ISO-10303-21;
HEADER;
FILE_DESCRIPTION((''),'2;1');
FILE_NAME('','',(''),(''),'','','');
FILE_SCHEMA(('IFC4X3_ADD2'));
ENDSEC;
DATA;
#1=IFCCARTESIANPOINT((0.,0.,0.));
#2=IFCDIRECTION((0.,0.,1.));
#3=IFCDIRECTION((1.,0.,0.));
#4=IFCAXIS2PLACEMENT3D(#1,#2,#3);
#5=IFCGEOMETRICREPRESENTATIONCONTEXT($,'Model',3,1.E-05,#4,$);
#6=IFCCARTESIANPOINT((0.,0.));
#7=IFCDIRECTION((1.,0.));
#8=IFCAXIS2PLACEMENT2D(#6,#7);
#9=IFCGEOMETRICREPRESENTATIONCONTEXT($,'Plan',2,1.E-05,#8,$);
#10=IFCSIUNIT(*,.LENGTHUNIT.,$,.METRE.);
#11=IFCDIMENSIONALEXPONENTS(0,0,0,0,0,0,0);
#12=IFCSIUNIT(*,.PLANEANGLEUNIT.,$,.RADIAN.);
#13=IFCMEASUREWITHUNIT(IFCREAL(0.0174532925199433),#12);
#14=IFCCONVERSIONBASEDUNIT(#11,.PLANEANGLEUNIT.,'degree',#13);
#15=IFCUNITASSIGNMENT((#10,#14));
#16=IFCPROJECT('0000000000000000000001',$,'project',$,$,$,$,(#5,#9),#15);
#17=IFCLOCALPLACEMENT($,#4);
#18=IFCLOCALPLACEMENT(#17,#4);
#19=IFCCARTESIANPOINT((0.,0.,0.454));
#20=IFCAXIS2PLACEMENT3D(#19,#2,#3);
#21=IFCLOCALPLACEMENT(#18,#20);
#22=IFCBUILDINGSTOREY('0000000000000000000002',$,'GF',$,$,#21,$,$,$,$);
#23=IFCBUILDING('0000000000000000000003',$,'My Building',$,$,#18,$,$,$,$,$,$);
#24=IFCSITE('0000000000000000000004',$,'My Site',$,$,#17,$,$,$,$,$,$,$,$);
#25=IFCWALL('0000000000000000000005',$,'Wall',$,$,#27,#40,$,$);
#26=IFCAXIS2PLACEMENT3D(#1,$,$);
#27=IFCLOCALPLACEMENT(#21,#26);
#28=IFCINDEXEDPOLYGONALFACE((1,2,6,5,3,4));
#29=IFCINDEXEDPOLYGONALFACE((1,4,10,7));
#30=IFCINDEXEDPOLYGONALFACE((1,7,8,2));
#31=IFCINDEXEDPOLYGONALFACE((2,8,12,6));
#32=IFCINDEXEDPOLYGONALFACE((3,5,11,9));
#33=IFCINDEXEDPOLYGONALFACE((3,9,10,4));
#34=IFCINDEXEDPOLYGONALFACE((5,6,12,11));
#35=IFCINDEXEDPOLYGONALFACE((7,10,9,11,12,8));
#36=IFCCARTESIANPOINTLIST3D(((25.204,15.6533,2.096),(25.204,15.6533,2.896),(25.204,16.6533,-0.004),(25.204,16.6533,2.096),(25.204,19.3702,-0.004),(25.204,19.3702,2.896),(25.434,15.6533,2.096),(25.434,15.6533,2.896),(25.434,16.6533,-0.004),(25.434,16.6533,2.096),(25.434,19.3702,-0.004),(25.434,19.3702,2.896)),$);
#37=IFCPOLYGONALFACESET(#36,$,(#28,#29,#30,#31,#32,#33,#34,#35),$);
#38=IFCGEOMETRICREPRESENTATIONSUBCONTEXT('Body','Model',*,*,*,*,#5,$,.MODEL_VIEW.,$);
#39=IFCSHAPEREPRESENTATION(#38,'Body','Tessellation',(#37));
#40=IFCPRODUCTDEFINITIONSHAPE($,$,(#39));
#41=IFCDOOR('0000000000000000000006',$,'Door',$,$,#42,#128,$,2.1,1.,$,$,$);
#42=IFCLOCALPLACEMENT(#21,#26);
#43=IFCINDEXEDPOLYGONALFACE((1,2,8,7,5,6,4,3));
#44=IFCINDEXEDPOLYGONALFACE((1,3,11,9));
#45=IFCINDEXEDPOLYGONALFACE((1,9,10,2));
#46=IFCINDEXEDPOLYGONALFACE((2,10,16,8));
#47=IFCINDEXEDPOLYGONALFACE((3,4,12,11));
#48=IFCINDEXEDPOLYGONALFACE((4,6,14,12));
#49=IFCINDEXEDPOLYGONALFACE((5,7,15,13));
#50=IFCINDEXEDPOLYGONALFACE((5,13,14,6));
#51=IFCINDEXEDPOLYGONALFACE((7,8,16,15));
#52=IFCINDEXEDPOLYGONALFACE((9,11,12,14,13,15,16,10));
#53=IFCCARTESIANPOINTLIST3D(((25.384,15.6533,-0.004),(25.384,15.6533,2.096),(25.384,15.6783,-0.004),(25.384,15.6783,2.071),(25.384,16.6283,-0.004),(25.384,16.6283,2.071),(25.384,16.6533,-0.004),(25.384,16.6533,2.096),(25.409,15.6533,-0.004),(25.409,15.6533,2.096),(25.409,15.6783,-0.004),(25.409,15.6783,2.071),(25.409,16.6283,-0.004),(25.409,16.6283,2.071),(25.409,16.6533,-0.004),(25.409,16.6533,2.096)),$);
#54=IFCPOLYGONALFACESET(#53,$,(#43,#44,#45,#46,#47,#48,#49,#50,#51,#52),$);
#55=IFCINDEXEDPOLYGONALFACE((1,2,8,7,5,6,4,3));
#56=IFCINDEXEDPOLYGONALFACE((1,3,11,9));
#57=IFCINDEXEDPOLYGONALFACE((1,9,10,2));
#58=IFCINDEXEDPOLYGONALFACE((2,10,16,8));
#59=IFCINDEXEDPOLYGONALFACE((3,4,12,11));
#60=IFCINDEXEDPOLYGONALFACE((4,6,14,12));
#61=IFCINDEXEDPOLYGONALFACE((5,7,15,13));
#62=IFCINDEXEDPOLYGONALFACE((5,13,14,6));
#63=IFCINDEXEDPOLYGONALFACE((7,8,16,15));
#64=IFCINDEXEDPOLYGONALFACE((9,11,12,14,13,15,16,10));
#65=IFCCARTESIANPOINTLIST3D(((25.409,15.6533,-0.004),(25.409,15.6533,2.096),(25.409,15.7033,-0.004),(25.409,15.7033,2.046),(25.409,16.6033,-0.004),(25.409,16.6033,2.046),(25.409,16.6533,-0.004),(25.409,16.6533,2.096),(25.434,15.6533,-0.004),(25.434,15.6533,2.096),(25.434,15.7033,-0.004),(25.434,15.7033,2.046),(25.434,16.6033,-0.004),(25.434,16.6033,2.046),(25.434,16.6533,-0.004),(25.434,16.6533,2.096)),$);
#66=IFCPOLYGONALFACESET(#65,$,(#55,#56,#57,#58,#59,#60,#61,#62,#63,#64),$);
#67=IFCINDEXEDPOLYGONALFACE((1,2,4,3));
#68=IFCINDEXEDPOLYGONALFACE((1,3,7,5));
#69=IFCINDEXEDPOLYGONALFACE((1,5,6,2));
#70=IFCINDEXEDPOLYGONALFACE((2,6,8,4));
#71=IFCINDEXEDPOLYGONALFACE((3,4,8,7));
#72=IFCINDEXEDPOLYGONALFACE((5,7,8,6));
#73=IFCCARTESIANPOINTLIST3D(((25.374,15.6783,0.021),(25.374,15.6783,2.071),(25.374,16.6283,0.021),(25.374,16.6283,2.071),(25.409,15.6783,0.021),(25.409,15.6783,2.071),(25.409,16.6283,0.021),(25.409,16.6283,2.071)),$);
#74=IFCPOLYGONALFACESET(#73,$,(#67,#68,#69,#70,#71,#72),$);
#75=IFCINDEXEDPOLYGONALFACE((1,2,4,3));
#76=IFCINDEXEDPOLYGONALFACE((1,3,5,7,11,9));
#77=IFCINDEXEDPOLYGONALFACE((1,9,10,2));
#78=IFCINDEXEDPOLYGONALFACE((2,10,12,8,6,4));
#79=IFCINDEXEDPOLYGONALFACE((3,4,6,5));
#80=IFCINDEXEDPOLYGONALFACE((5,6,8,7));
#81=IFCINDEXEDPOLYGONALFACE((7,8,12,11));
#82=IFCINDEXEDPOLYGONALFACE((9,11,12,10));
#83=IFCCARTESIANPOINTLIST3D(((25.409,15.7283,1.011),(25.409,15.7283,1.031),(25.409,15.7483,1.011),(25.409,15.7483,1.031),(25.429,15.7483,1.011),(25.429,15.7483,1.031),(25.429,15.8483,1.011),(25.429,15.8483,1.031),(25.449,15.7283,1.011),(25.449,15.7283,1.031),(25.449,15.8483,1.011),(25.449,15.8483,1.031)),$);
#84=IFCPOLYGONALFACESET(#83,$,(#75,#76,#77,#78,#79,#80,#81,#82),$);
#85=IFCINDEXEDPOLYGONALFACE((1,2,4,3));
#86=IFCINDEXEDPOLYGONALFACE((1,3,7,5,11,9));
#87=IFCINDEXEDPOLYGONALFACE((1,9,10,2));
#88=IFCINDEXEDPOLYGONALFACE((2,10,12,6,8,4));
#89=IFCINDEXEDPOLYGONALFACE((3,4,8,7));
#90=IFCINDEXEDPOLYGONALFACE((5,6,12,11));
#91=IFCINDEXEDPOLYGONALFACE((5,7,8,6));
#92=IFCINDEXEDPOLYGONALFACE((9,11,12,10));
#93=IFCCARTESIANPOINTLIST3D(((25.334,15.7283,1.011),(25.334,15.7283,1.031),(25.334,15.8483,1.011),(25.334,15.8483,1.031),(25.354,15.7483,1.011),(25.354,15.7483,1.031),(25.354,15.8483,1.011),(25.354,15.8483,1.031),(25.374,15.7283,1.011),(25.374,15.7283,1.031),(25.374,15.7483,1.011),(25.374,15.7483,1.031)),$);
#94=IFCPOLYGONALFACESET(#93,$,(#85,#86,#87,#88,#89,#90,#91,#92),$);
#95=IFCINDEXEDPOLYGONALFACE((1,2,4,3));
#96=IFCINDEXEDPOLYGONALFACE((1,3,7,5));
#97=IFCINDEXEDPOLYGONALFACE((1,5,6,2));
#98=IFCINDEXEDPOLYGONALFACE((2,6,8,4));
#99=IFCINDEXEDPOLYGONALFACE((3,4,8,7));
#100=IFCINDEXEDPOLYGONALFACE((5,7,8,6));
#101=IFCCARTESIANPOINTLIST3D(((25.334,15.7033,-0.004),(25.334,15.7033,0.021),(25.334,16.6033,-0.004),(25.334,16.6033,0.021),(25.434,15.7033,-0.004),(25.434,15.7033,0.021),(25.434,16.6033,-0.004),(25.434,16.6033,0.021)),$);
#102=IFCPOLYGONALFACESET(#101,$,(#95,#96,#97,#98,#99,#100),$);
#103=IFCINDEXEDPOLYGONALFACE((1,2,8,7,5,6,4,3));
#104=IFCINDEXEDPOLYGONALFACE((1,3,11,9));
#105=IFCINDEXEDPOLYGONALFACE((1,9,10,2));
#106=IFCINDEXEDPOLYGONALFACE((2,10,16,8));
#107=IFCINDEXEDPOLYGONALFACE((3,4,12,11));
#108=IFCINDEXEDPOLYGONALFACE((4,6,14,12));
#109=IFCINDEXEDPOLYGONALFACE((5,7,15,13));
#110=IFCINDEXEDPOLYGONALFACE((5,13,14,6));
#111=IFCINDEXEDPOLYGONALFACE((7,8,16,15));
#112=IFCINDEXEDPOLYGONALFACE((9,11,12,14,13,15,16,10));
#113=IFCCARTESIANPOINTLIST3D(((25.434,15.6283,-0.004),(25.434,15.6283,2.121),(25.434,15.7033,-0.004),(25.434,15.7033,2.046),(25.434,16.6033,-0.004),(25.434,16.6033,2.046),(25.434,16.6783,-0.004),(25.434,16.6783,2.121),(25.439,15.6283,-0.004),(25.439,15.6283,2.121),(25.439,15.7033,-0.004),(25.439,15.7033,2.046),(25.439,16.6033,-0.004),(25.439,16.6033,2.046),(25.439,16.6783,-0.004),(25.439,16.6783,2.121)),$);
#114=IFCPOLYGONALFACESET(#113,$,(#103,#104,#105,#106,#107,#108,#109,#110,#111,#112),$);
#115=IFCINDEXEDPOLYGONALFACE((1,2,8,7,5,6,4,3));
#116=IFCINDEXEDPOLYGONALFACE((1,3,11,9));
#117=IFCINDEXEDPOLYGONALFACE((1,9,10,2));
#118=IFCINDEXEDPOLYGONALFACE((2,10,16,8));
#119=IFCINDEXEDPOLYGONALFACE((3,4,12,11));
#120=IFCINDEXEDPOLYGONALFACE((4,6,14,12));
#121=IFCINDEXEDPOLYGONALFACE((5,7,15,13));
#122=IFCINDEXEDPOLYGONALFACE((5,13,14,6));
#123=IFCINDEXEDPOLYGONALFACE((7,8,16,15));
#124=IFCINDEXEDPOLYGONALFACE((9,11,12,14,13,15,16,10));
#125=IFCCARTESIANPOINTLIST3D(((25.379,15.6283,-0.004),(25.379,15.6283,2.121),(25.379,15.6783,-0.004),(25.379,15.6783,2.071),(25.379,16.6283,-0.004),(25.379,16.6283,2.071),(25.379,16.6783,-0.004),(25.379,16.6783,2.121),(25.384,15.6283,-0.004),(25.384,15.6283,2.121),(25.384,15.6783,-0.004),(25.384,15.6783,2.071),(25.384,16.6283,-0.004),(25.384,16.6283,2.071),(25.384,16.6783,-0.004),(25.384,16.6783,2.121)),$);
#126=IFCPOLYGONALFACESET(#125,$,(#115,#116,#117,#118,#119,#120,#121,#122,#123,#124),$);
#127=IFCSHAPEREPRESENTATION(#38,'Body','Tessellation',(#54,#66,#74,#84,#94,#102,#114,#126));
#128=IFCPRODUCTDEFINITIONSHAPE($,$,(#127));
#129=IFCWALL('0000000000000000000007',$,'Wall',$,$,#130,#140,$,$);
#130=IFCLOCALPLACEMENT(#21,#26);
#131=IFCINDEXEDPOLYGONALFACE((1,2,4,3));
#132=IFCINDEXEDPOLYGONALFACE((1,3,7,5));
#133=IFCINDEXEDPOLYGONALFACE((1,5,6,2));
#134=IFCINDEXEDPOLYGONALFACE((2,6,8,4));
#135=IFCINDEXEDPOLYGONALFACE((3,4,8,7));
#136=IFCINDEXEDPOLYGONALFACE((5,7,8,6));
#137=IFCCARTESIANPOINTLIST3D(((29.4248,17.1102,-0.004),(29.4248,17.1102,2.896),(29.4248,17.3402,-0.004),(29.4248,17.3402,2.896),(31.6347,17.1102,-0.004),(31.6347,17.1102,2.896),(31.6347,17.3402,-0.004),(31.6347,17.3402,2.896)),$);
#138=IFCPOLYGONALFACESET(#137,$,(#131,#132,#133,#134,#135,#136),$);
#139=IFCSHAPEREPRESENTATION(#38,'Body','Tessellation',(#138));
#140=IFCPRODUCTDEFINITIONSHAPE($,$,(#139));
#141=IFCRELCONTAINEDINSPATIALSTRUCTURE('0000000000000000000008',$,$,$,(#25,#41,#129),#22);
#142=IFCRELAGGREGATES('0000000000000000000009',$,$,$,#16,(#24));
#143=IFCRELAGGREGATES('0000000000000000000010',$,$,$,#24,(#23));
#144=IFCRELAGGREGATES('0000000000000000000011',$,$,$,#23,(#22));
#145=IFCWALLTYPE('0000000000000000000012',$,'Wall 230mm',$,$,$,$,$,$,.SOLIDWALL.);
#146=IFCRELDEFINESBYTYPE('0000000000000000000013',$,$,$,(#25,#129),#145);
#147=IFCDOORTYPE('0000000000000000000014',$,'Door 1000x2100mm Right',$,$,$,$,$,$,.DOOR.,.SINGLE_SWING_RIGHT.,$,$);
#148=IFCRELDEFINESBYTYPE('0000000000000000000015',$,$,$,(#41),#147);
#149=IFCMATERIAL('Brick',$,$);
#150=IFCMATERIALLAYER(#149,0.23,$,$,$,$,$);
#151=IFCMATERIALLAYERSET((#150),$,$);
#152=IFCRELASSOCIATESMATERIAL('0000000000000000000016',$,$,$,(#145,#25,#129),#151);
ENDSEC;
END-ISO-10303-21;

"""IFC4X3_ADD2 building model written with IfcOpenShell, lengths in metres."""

from ifc_helpers import new_model, entity, si_unit, converted_unit, frame, origin_with_axes, origin_2d_with_axis, place, context, subcontext, project, spatial, line, indexed_curve, outline, extrude, shape, source, transform, mapped, material, layer, layer_set, layer_usage, type_object, type_shapes, element, fill, save


model = new_model("IFC4X3_ADD2")

# Units and contexts
model_context = context("Model", 3, precision=1e-05, world=origin_with_axes())
plan_context = context("Plan", 2, precision=1e-05, world=origin_2d_with_axis())
body_context_1 = subcontext(model_context, "Body", "Model", "MODEL_VIEW")
body_context_2 = subcontext(plan_context, "Body", "Plan", "PLAN_VIEW")
ifc_project = project(units=[si_unit("LENGTHUNIT", "METRE"), converted_unit("PLANEANGLEUNIT", "degree", entity("IfcReal", 0.0174532925199433), si_unit("PLANEANGLEUNIT", "RADIAN"), dimensions=[0, 0, 0, 0, 0, 0, 0])], contexts=[model_context, plan_context])

# Site, building, storey
site_placement = place(None, origin_with_axes())
site = spatial("IfcSite", under=ifc_project, at=site_placement, Name="My Site")
building_placement = place(site_placement, origin_with_axes())
building = spatial("IfcBuilding", under=site, at=building_placement, Name="My Building")
storey_placement = place(building_placement, frame((0.0, 0.0, 0.454), z_axis=(0.0, 0.0, 1.0), x_axis=(1.0, 0.0, 0.0)))
storey = spatial("IfcBuildingStorey", under=building, at=storey_placement, Name="GF")

# Shared definitions
ifc_material_1 = material(Name="Brick")

# Shared definitions
ifc_layer_1 = layer(ifc_material_1, 0.23)
ifc_layer_set_1 = layer_set([ifc_layer_1])
wall_type_1 = type_object("IfcWallType", Name="Wall 230mm", PredefinedType="SOLIDWALL", material=ifc_layer_set_1)

# Wall, opening, door
ifc_layer_usage_1 = layer_usage(ifc_layer_set_1, "AXIS2", "POSITIVE", 0.0)
wall_1_placement = place(storey_placement, frame((25.434, 15.6533, -0.004), z_axis=(0.0, 0.0, 1.0), x_axis=(0.000001, 1.0, 0.0)))
wall_1 = element("IfcWall", 1, at=wall_1_placement, inside=storey, type_object=wall_type_1, material=ifc_layer_usage_1, Name="Wall", context=body_context_1, shape_type="SweptSolid", body=[
    extrude(outline(indexed_curve([(0.0, 0.0), (0.0, 0.23), (3.7169, 0.23), (3.7169, 0.0), (0.0, 0.0)], self_intersect=False)), origin_with_axes(), (0.0, 0.0, 1.0), 2.9),
])
shared_shape_1 = source(origin_with_axes(), body_context_1, "Body", "SweptSolid", [
    extrude(outline(indexed_curve([(0.0, 0.0), (1.0, 0.0), (1.0, 2.1), (0.0, 2.1)], segments=[line(1, 2, 3, 4, 1)])), frame((0.0, -0.6, 0.0), z_axis=(0.0, -1.0, 0.0), x_axis=(1.0, 0.0, 0.0)), (0.0, 0.0, -1.0), 1.2),
])
opening_1_placement = place(wall_1_placement, origin_with_axes())
opening_1 = element("IfcOpeningElement", 2, at=opening_1_placement, cuts=wall_1, PredefinedType="OPENING", context=body_context_1, shape_type="MappedRepresentation", body=[
    mapped(shared_shape_1, transform((0.0, 0.0, 0.0), x_axis=(1.0, 0.0, 0.0), y_axis=(0.0, 1.0, 0.0), z_axis=(0.0, 0.0, 1.0), scale=1.0)),
])
door_type_1 = type_object("IfcDoorType", Name="Door 1000x2100mm Right", OperationType="SINGLE_SWING_RIGHT", PredefinedType="DOOR")
shared_shape_2 = source(origin_with_axes(), body_context_1, "Body", "SweptSolid", [
    extrude(outline(indexed_curve([(0.0, 0.0), (0.0, 2.1), (1.0, 2.1), (1.0, 0.0), (0.975, 0.0), (0.975, 2.075), (0.025, 2.075), (0.025, 0.0)], segments=[line(1, 2, 3, 4, 5, 6, 7, 8, 1)])), frame((0.0, 0.025, 0.0), z_axis=(0.0, -1.0, 0.0), x_axis=(1.0, 0.0, 0.0)), (0.0, 0.0, -1.0), 0.025),
    extrude(outline(indexed_curve([(0.0, 0.0), (0.0, 2.1), (1.0, 2.1), (1.0, 0.0), (0.95, 0.0), (0.95, 2.05), (0.05, 2.05), (0.05, 0.0)], segments=[line(1, 2, 3, 4, 5, 6, 7, 8, 1)])), frame((0.0, 0.0, 0.0), z_axis=(0.0, -1.0, 0.0), x_axis=(1.0, 0.0, 0.0)), (0.0, 0.0, -1.0), 0.025),
    extrude(outline(indexed_curve([(0.0, 0.0), (0.95, 0.0), (0.95, 0.035), (0.0, 0.035)], segments=[line(1, 2, 3, 4, 1)])), frame((0.025, 0.025, 0.025), z_axis=(0.0, 0.0, 1.0), x_axis=(1.0, 0.0, 0.0)), (0.0, 0.0, 1.0), 2.05),
    extrude(outline(indexed_curve([(0.0, 0.0), (0.0, -0.04), (0.12, -0.04), (0.12, -0.02), (0.02, -0.02), (0.02, 0.0)], segments=[line(1, 2, 3, 4, 5, 6, 1)])), frame((0.075, 0.025, 1.015), z_axis=(0.0, 0.0, 1.0), x_axis=(1.0, 0.0, 0.0)), (0.0, 0.0, 1.0), 0.02),
    extrude(outline(indexed_curve([(0.0, 0.0), (0.0, 0.04), (0.12, 0.04), (0.12, 0.02), (0.02, 0.02), (0.02, 0.0)], segments=[line(1, 2, 3, 4, 5, 6, 1)])), frame((0.075, 0.06, 1.015), z_axis=(0.0, 0.0, 1.0), x_axis=(1.0, 0.0, 0.0)), (0.0, 0.0, 1.0), 0.02),
    extrude(outline(indexed_curve([(0.0, 0.0), (0.9, 0.0), (0.9, 0.1), (0.0, 0.1)], segments=[line(1, 2, 3, 4, 1)])), frame((0.05, 0.0, 0.0), z_axis=(0.0, 0.0, 1.0), x_axis=(1.0, 0.0, 0.0)), (0.0, 0.0, 1.0), 0.025),
    extrude(outline(indexed_curve([(0.0, 0.0), (0.0, 2.125), (1.05, 2.125), (1.05, 0.0), (0.975, 0.0), (0.975, 2.05), (0.075, 2.05), (0.075, 0.0)], segments=[line(1, 2, 3, 4, 5, 6, 7, 8, 1)])), frame((-0.025, -0.005, 0.0), z_axis=(0.0, -1.0, 0.0), x_axis=(1.0, 0.0, 0.0)), (0.0, 0.0, -1.0), 0.005),
    extrude(outline(indexed_curve([(0.0, 0.0), (0.0, 2.125), (1.05, 2.125), (1.05, 0.0), (1.0, 0.0), (1.0, 2.075), (0.05, 2.075), (0.05, 0.0)], segments=[line(1, 2, 3, 4, 5, 6, 7, 8, 1)])), frame((-0.025, 0.05, 0.0), z_axis=(0.0, -1.0, 0.0), x_axis=(1.0, 0.0, 0.0)), (0.0, 0.0, -1.0), 0.005),
])
shared_shape_3 = source(origin_with_axes(), body_context_2, "Body", "Curve2D", [
    entity("IfcIndexedPolyCurve", entity("IfcCartesianPointList2D", [[0.0, 0.0], [0.0, 0.05], [0.025, 0.05], [0.025, 0.025], [0.05, 0.025], [0.05, 0.0]]), [entity("IfcLineIndex", [1, 2, 3, 4, 5, 6, 1])]),
    entity("IfcIndexedPolyCurve", entity("IfcCartesianPointList2D", [[1.0, 0.0], [1.0, 0.05], [0.975, 0.05], [0.975, 0.025], [0.95, 0.025], [0.95, 0.0]]), [entity("IfcLineIndex", [1, 2, 3, 4, 5, 6, 1])]),
    entity("IfcTrimmedCurve", entity("IfcEllipse", entity("IfcAxis2Placement2D", entity("IfcCartesianPoint", [0.94, 0.05]), entity("IfcDirection", [1.0, 0.0])), 0.915, 0.95), [entity("IfcCartesianPoint", [0.94, 1.0])], [entity("IfcCartesianPoint", [0.025, 0.05])], True, "CARTESIAN"),
    entity("IfcIndexedPolyCurve", entity("IfcCartesianPointList2D", [[0.975, 0.05], [0.94, 0.05], [0.94, 1.0], [0.975, 1.0]]), [entity("IfcLineIndex", [1, 2, 3, 4, 1])]),
])
type_shapes(door_type_1, [shared_shape_2, shared_shape_3])
door_1_placement = place(opening_1_placement, origin_with_axes())
door_1 = element("IfcDoor", 3, at=door_1_placement, inside=storey, type_object=door_type_1, Name="Door", OverallHeight=2.1, OverallWidth=1.0, shapes=[
    shape(body_context_1, "Body", "MappedRepresentation", [mapped(shared_shape_2, transform((0.0, 0.0, 0.0), x_axis=(1.0, 0.0, 0.0), y_axis=(0.0, 1.0, 0.0), z_axis=(0.0, 0.0, 1.0), scale=1.0))]),
    shape(body_context_2, "Body", "MappedRepresentation", [mapped(shared_shape_3, transform((0.0, 0.0, 0.0), x_axis=(1.0, 0.0, 0.0), y_axis=(0.0, 1.0, 0.0), z_axis=(0.0, 0.0, 1.0), scale=1.0))]),
])
fill(opening_1, door_1)

# Wall
ifc_layer_usage_2 = layer_usage(ifc_layer_set_1, "AXIS2", "POSITIVE", 0.0)
wall_2_placement = place(storey_placement, frame((31.6347, 17.3402, -0.004), z_axis=(0.0, 0.0, 1.0), x_axis=(-1.0, 0.0, 0.0)))
element("IfcWall", 4, at=wall_2_placement, inside=storey, type_object=wall_type_1, material=ifc_layer_usage_2, Name="Wall", context=body_context_1, shape_type="SweptSolid", body=[
    extrude(outline(indexed_curve([(0.0, 0.0), (0.0, 0.23), (2.21, 0.23), (2.21, 0.0), (0.0, 0.0)], self_intersect=False)), origin_with_axes(), (0.0, 0.0, 1.0), 2.9),
])

save(model, "model.ifc")
